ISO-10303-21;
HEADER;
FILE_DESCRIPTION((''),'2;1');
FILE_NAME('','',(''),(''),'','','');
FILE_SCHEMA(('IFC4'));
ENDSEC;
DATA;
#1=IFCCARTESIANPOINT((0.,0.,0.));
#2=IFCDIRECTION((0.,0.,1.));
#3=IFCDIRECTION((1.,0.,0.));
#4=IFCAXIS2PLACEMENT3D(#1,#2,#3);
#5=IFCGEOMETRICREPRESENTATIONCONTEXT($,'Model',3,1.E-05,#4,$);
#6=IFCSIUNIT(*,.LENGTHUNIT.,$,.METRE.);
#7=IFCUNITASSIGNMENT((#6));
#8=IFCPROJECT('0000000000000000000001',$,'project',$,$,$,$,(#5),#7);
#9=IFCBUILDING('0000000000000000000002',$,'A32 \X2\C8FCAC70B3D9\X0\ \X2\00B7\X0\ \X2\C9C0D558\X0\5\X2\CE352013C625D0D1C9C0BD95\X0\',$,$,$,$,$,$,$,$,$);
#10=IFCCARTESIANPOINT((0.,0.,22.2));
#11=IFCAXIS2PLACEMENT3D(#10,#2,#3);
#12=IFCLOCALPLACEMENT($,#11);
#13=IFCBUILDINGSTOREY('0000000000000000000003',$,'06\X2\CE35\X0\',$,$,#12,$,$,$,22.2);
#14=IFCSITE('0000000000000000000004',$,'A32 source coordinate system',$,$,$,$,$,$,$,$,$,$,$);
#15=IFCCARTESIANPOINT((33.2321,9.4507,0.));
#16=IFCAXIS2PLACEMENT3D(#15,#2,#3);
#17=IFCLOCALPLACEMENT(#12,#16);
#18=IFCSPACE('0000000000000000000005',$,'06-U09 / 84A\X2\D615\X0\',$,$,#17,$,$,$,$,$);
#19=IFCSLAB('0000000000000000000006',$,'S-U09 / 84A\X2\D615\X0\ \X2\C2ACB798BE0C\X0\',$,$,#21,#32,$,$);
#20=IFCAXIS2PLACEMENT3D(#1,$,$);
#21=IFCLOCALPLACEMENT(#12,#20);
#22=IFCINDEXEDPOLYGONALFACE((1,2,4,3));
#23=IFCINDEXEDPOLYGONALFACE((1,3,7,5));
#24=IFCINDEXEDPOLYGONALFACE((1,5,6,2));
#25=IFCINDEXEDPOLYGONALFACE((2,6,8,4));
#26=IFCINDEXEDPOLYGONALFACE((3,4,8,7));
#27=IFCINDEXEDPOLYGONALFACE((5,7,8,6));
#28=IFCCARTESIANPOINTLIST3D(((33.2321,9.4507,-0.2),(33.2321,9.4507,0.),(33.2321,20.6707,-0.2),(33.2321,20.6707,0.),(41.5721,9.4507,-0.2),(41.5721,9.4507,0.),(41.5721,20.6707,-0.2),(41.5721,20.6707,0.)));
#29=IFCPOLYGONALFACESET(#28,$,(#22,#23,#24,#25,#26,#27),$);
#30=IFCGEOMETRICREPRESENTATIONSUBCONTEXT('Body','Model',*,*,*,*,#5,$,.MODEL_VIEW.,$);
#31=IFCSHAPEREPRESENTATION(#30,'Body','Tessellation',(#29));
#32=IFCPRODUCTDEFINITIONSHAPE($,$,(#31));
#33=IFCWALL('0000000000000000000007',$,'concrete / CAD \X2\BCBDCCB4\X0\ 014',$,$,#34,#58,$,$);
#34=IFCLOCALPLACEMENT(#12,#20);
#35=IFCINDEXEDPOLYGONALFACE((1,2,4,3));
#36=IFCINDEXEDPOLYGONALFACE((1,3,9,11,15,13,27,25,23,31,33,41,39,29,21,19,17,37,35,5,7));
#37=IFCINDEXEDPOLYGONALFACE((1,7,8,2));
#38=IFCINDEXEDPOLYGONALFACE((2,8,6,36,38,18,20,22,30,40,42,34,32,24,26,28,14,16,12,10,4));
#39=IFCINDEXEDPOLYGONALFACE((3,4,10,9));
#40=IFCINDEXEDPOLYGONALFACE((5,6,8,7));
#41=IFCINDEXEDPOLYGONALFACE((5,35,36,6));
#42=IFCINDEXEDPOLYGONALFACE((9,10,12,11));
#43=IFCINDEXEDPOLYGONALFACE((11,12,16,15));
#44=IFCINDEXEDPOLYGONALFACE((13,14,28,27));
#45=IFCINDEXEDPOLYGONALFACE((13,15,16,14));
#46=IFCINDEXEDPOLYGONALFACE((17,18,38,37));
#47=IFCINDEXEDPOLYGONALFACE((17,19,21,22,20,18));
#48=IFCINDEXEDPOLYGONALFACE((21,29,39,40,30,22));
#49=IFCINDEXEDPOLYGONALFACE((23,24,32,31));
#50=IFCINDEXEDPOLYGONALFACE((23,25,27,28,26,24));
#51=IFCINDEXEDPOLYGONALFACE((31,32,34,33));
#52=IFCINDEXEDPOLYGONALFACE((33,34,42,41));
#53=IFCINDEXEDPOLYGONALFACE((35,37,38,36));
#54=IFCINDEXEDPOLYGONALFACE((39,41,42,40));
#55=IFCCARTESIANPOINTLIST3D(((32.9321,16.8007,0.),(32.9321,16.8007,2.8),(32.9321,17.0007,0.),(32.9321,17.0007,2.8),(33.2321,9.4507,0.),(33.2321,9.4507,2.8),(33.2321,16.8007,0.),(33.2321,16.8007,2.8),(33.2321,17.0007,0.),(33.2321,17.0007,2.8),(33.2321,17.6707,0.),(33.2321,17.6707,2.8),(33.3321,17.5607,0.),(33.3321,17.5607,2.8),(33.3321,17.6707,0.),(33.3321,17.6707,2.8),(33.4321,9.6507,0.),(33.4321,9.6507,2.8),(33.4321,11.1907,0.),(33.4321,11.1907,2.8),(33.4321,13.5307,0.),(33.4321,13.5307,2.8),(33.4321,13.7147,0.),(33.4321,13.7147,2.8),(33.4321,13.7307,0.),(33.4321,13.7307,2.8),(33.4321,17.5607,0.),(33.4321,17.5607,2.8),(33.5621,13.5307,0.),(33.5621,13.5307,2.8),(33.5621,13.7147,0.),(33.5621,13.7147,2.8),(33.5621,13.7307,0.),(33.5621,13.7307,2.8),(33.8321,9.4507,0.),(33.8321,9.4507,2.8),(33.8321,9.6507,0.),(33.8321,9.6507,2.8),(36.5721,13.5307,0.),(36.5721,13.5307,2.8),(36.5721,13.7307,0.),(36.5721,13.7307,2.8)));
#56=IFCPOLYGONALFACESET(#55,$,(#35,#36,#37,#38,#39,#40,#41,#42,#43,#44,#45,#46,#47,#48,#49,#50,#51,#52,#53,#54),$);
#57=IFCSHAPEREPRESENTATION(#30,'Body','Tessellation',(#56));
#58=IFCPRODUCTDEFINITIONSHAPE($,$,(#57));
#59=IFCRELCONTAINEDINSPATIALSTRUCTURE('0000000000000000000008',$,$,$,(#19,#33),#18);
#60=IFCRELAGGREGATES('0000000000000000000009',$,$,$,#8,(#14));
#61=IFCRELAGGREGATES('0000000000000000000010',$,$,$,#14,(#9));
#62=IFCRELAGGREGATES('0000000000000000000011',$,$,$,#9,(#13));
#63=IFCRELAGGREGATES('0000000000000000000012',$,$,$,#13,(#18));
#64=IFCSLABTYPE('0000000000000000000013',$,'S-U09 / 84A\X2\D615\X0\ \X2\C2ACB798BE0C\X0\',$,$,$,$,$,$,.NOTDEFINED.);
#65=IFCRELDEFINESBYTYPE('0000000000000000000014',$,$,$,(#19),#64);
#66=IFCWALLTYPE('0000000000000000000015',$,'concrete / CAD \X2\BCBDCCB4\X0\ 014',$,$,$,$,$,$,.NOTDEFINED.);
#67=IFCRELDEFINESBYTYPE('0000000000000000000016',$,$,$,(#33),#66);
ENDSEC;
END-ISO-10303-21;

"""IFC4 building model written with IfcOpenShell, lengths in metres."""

from ifc_helpers import new_model, si_unit, frame, origin, origin_with_axes, place, context, subcontext, project, spatial, polyline, outline, extrude, source, transform, mapped, type_object, type_shapes, element, save


model = new_model("IFC4")

# Units and contexts
model_context = context("Model", 3, precision=1e-05, world=origin_with_axes())
body_context = subcontext(model_context, "Body", "Model", "MODEL_VIEW")
ifc_project = project(units=[si_unit("LENGTHUNIT", "METRE")], contexts=[model_context])

# Site, building, storey, space
storey_placement = place(None, frame((0.0, 0.0, 22.2), z_axis=(0.0, 0.0, 1.0), x_axis=(1.0, 0.0, 0.0)))
space_placement = place(storey_placement, frame((33.2321, 9.4507, 0.0), z_axis=(0.0, 0.0, 1.0), x_axis=(1.0, 0.0, 0.0)))
site = spatial("IfcSite", under=ifc_project, Name="A32 source coordinate system")
building = spatial("IfcBuilding", under=site, Name="A32 주거동 · 지하5층–옥탑지붕")
storey = spatial("IfcBuildingStorey", under=building, at=storey_placement, Name="06층", Elevation=22.2)
space = spatial("IfcSpace", under=storey, at=space_placement, Name="06-U09 / 84A형")

# Slab
slab_type_1 = type_object("IfcSlabType", Name="S-U09 / 84A형 슬래브", PredefinedType="NOTDEFINED")
shared_shape_1 = source(origin(), body_context, "Body", "SweptSolid", [
    extrude(outline(polyline([(0.0, 11.22), (8.34, 11.22), (8.34, 0.0), (0.0, 0.0), (0.0, 11.22)])), frame((0.0, 0.0, -0.2)), (0.0, 0.0, 1.0), 0.2),
])
type_shapes(slab_type_1, [shared_shape_1])
slab_1_placement = place(space_placement, origin_with_axes())
element("IfcSlab", 1, at=slab_1_placement, inside=space, type_object=slab_type_1, Name="S-U09 / 84A형 슬래브", context=body_context, shape_type="MappedRepresentation", body=[
    mapped(shared_shape_1, transform((0.0, 0.0, 0.0), scale=1.0)),
])

# Wall
wall_type_1 = type_object("IfcWallType", Name="concrete / CAD 벽체 014", PredefinedType="NOTDEFINED")
shared_shape_2 = source(origin(), body_context, "Body", "SweptSolid", [
    extrude(outline(polyline([(3.34, 4.08), (0.33, 4.08), (0.2, 4.08), (0.2, 1.74), (0.2, 0.2), (0.6, 0.2), (0.6, 0.0), (0.0, 0.0), (0.0, 7.35), (-0.3, 7.35), (-0.3, 7.55), (0.0, 7.55), (0.0, 8.22), (0.1, 8.22), (0.1, 8.11), (0.2, 8.11), (0.2, 4.28), (0.2, 4.264), (0.33, 4.264), (0.33, 4.28), (3.34, 4.28), (3.34, 4.08)])), origin(), (0.0, 0.0, 1.0), 2.8),
])
type_shapes(wall_type_1, [shared_shape_2])
wall_1_placement = place(space_placement, origin_with_axes())
element("IfcWall", 2, at=wall_1_placement, inside=space, type_object=wall_type_1, Name="concrete / CAD 벽체 014", context=body_context, shape_type="MappedRepresentation", body=[
    mapped(shared_shape_2, transform((0.0, 0.0, 0.0), scale=1.0)),
])

save(model, "model.ifc")
